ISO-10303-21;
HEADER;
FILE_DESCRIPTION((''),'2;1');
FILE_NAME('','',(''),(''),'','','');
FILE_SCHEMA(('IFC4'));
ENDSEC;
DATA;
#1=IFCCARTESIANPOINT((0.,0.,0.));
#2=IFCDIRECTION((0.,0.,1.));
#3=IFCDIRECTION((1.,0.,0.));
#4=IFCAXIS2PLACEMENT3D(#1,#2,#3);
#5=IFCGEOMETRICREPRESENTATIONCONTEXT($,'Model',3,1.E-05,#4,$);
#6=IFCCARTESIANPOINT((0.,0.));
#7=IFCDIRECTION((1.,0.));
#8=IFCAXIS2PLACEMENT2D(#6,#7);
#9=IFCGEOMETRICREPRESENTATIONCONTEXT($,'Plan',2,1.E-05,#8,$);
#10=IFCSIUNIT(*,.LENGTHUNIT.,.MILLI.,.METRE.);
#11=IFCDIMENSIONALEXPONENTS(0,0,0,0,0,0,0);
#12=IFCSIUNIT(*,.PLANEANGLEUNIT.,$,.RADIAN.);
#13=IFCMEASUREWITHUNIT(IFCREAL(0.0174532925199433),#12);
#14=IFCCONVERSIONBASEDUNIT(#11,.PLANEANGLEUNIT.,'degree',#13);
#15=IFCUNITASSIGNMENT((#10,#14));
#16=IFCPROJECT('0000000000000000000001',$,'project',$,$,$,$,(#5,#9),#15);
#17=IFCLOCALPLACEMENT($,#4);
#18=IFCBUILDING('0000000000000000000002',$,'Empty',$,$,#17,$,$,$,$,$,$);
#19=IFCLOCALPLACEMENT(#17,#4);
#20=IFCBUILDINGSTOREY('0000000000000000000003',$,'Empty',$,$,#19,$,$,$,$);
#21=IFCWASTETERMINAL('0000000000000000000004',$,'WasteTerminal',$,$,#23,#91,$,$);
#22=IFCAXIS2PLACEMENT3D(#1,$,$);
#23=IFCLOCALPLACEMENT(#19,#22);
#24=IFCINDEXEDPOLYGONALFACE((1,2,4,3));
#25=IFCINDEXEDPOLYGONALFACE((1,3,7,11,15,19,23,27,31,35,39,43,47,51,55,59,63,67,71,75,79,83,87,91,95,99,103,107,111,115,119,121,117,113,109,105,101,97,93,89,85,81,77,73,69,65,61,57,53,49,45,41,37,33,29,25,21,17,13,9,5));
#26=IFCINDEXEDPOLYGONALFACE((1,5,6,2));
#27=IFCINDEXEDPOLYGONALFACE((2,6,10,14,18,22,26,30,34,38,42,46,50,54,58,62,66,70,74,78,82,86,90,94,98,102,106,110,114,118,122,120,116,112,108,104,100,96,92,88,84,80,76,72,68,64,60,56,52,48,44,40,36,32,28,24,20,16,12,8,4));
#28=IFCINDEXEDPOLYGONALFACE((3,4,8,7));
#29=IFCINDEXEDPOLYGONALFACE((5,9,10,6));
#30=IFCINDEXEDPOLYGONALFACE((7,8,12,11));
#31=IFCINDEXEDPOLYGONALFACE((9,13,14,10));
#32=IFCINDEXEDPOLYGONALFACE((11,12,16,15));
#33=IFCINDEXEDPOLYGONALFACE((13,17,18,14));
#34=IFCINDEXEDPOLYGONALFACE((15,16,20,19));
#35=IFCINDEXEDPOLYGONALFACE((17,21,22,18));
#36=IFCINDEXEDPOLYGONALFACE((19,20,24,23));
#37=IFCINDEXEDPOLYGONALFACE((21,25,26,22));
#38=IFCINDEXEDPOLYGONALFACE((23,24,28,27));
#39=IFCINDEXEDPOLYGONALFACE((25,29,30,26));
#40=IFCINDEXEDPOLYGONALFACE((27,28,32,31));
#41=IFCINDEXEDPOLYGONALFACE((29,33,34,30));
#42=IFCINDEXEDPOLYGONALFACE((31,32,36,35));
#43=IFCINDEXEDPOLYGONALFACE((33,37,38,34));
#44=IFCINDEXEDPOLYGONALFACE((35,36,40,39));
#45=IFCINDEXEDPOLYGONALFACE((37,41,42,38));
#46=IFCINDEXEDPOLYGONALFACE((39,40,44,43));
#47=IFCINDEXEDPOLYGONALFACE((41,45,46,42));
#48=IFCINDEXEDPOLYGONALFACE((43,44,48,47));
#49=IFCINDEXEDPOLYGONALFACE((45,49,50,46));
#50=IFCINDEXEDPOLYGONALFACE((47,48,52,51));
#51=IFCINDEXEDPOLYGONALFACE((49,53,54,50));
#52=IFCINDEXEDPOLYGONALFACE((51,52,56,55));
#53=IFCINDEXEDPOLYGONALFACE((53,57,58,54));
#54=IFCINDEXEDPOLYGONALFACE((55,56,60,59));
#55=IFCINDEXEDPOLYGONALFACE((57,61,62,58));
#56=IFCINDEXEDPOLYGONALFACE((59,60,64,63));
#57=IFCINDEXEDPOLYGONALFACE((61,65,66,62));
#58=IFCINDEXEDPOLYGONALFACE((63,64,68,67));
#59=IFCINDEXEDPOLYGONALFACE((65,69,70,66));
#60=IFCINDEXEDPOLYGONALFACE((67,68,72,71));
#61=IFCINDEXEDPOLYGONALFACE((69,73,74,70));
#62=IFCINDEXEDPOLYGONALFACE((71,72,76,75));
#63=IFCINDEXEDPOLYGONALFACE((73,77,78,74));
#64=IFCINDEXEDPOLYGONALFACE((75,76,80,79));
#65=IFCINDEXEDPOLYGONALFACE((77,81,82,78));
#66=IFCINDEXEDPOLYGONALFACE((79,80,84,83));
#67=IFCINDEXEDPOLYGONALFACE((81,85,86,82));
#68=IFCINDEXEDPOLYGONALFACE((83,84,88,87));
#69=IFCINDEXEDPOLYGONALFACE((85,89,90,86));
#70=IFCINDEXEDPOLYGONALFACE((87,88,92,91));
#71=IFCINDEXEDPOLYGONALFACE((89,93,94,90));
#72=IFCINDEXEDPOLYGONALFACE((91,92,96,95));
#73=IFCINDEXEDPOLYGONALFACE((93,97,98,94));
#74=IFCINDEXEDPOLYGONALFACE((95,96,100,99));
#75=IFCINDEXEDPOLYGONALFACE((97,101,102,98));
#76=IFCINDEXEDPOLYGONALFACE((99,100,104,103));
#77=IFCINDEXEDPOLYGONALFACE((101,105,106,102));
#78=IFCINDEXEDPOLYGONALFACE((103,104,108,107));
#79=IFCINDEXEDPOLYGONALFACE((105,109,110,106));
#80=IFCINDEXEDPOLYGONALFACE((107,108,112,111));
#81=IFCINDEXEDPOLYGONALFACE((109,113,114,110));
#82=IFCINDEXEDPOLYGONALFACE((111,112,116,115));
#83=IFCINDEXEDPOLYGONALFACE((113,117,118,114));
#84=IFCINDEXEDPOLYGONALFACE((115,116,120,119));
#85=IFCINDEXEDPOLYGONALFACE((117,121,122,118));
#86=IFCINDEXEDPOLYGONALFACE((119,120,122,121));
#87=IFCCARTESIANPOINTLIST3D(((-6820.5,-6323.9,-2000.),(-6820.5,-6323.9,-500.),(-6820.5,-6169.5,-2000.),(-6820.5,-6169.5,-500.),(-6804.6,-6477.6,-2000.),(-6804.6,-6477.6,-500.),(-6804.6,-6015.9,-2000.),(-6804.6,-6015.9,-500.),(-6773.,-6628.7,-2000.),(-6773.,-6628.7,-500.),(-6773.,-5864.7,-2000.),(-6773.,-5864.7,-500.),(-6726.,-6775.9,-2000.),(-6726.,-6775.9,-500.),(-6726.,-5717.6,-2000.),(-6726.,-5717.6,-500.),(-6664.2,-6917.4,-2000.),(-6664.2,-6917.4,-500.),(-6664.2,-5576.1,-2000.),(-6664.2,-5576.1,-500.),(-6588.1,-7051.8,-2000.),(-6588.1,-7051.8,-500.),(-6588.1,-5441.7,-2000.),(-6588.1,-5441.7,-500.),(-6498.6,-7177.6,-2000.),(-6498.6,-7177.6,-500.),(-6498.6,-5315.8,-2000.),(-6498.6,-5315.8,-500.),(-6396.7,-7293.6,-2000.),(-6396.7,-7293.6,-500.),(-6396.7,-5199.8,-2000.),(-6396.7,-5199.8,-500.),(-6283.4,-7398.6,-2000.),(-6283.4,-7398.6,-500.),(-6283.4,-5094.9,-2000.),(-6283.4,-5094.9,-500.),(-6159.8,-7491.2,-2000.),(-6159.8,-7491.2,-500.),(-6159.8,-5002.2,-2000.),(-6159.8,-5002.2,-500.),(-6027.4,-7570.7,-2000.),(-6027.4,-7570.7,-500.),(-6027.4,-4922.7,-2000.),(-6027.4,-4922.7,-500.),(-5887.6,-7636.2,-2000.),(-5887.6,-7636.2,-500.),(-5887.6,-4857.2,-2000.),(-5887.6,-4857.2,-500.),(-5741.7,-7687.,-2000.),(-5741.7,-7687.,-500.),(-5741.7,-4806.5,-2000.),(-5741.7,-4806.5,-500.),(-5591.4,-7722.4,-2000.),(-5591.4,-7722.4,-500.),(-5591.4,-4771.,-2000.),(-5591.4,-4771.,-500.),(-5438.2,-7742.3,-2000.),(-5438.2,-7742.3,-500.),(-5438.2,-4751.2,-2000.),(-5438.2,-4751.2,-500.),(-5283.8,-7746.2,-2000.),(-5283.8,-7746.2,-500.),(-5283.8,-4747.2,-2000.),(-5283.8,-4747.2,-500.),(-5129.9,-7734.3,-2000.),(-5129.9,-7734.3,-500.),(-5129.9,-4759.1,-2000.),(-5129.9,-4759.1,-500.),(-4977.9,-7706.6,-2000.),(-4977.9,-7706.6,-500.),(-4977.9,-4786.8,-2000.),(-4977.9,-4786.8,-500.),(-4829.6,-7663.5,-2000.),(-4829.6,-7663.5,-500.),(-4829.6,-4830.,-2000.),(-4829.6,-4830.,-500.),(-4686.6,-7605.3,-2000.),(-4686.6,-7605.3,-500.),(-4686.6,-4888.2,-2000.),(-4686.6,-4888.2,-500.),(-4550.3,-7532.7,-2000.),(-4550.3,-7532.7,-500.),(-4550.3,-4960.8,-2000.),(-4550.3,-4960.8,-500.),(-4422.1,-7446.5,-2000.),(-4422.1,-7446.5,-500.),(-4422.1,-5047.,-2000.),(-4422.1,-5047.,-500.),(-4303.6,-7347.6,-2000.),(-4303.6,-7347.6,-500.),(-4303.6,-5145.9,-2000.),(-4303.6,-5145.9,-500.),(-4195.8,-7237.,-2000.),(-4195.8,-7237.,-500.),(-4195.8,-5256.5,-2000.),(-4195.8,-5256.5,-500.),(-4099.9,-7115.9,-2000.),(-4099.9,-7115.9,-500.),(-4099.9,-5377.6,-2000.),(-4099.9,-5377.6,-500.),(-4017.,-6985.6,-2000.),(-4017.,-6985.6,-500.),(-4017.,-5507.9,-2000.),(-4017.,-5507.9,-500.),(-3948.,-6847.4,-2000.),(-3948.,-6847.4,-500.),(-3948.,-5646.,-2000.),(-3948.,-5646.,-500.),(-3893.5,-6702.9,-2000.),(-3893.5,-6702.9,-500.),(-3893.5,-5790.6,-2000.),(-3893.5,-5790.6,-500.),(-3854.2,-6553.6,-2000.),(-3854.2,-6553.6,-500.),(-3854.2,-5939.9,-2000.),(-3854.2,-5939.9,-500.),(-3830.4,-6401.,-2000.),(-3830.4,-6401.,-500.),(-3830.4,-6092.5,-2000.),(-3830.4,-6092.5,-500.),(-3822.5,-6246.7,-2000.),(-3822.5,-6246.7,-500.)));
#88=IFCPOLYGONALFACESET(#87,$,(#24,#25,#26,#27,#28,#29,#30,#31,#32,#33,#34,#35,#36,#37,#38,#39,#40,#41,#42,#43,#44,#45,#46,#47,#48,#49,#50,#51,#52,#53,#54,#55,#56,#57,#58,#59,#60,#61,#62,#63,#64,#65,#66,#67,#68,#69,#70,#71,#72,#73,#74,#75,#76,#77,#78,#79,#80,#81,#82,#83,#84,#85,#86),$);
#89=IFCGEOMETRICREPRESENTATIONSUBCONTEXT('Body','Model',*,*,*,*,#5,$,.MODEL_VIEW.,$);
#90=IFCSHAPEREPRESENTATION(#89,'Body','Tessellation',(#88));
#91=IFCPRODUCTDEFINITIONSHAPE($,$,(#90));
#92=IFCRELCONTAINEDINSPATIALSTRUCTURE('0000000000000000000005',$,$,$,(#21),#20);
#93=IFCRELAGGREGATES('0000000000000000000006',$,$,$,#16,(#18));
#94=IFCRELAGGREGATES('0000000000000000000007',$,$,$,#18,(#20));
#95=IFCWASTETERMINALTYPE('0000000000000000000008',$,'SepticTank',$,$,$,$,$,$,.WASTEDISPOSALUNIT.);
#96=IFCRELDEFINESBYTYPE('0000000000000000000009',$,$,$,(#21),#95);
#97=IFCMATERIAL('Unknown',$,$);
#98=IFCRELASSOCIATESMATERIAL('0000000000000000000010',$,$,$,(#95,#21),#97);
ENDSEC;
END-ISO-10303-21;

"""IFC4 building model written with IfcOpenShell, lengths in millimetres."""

from ifc_helpers import new_model, entity, si_unit, converted_unit, frame, origin_with_axes, origin_2d_with_axis, place, context, subcontext, project, spatial, circle, extrude, material, material_profile, profile_set, profile_usage, type_object, element, save


model = new_model("IFC4")

# Units and contexts
model_context = context("Model", 3, precision=1e-05, world=origin_with_axes())
plan_context = context("Plan", 2, precision=1e-05, world=origin_2d_with_axis())
body_context = subcontext(model_context, "Body", "Model", "MODEL_VIEW")
ifc_project = project(units=[si_unit("LENGTHUNIT", "METRE", prefix="MILLI"), converted_unit("PLANEANGLEUNIT", "degree", entity("IfcReal", 0.0174532925199433), si_unit("PLANEANGLEUNIT", "RADIAN"), dimensions=[0, 0, 0, 0, 0, 0, 0])], contexts=[model_context, plan_context])

# Building, storey
building_placement = place(None, origin_with_axes())
building = spatial("IfcBuilding", under=ifc_project, at=building_placement, Name="Empty")
storey_placement = place(building_placement, origin_with_axes())
storey = spatial("IfcBuildingStorey", under=building, at=storey_placement, Name="Empty")

# Shared definitions
ifc_material_1 = material(Name="Unknown")

# Waste terminal
ifc_material_profile_1 = material_profile(ifc_material_1, circle(Radius=1500.0))
ifc_profile_set_1 = profile_set([ifc_material_profile_1])
ifc_profile_usage_1 = profile_usage(ifc_profile_set_1, cardinal=5)
waste_terminal_type = type_object("IfcWasteTerminalType", Name="SepticTank", PredefinedType="WASTEDISPOSALUNIT", material=ifc_profile_set_1)
waste_terminal_placement = place(storey_placement, frame((-5322.5, -6246.7, -2000.0), z_axis=(0.0, 0.0, 1.0), x_axis=(1.0, 0.0, 0.0)))
element("IfcWasteTerminal", 1, at=waste_terminal_placement, inside=storey, type_object=waste_terminal_type, material=ifc_profile_usage_1, Name="WasteTerminal", context=body_context, shape_type="SweptSolid", body=[
    extrude(circle(Radius=1500.0), origin_with_axes(), (0.0, 0.0, 1.0), 1500.0),
])

save(model, "model.ifc")
